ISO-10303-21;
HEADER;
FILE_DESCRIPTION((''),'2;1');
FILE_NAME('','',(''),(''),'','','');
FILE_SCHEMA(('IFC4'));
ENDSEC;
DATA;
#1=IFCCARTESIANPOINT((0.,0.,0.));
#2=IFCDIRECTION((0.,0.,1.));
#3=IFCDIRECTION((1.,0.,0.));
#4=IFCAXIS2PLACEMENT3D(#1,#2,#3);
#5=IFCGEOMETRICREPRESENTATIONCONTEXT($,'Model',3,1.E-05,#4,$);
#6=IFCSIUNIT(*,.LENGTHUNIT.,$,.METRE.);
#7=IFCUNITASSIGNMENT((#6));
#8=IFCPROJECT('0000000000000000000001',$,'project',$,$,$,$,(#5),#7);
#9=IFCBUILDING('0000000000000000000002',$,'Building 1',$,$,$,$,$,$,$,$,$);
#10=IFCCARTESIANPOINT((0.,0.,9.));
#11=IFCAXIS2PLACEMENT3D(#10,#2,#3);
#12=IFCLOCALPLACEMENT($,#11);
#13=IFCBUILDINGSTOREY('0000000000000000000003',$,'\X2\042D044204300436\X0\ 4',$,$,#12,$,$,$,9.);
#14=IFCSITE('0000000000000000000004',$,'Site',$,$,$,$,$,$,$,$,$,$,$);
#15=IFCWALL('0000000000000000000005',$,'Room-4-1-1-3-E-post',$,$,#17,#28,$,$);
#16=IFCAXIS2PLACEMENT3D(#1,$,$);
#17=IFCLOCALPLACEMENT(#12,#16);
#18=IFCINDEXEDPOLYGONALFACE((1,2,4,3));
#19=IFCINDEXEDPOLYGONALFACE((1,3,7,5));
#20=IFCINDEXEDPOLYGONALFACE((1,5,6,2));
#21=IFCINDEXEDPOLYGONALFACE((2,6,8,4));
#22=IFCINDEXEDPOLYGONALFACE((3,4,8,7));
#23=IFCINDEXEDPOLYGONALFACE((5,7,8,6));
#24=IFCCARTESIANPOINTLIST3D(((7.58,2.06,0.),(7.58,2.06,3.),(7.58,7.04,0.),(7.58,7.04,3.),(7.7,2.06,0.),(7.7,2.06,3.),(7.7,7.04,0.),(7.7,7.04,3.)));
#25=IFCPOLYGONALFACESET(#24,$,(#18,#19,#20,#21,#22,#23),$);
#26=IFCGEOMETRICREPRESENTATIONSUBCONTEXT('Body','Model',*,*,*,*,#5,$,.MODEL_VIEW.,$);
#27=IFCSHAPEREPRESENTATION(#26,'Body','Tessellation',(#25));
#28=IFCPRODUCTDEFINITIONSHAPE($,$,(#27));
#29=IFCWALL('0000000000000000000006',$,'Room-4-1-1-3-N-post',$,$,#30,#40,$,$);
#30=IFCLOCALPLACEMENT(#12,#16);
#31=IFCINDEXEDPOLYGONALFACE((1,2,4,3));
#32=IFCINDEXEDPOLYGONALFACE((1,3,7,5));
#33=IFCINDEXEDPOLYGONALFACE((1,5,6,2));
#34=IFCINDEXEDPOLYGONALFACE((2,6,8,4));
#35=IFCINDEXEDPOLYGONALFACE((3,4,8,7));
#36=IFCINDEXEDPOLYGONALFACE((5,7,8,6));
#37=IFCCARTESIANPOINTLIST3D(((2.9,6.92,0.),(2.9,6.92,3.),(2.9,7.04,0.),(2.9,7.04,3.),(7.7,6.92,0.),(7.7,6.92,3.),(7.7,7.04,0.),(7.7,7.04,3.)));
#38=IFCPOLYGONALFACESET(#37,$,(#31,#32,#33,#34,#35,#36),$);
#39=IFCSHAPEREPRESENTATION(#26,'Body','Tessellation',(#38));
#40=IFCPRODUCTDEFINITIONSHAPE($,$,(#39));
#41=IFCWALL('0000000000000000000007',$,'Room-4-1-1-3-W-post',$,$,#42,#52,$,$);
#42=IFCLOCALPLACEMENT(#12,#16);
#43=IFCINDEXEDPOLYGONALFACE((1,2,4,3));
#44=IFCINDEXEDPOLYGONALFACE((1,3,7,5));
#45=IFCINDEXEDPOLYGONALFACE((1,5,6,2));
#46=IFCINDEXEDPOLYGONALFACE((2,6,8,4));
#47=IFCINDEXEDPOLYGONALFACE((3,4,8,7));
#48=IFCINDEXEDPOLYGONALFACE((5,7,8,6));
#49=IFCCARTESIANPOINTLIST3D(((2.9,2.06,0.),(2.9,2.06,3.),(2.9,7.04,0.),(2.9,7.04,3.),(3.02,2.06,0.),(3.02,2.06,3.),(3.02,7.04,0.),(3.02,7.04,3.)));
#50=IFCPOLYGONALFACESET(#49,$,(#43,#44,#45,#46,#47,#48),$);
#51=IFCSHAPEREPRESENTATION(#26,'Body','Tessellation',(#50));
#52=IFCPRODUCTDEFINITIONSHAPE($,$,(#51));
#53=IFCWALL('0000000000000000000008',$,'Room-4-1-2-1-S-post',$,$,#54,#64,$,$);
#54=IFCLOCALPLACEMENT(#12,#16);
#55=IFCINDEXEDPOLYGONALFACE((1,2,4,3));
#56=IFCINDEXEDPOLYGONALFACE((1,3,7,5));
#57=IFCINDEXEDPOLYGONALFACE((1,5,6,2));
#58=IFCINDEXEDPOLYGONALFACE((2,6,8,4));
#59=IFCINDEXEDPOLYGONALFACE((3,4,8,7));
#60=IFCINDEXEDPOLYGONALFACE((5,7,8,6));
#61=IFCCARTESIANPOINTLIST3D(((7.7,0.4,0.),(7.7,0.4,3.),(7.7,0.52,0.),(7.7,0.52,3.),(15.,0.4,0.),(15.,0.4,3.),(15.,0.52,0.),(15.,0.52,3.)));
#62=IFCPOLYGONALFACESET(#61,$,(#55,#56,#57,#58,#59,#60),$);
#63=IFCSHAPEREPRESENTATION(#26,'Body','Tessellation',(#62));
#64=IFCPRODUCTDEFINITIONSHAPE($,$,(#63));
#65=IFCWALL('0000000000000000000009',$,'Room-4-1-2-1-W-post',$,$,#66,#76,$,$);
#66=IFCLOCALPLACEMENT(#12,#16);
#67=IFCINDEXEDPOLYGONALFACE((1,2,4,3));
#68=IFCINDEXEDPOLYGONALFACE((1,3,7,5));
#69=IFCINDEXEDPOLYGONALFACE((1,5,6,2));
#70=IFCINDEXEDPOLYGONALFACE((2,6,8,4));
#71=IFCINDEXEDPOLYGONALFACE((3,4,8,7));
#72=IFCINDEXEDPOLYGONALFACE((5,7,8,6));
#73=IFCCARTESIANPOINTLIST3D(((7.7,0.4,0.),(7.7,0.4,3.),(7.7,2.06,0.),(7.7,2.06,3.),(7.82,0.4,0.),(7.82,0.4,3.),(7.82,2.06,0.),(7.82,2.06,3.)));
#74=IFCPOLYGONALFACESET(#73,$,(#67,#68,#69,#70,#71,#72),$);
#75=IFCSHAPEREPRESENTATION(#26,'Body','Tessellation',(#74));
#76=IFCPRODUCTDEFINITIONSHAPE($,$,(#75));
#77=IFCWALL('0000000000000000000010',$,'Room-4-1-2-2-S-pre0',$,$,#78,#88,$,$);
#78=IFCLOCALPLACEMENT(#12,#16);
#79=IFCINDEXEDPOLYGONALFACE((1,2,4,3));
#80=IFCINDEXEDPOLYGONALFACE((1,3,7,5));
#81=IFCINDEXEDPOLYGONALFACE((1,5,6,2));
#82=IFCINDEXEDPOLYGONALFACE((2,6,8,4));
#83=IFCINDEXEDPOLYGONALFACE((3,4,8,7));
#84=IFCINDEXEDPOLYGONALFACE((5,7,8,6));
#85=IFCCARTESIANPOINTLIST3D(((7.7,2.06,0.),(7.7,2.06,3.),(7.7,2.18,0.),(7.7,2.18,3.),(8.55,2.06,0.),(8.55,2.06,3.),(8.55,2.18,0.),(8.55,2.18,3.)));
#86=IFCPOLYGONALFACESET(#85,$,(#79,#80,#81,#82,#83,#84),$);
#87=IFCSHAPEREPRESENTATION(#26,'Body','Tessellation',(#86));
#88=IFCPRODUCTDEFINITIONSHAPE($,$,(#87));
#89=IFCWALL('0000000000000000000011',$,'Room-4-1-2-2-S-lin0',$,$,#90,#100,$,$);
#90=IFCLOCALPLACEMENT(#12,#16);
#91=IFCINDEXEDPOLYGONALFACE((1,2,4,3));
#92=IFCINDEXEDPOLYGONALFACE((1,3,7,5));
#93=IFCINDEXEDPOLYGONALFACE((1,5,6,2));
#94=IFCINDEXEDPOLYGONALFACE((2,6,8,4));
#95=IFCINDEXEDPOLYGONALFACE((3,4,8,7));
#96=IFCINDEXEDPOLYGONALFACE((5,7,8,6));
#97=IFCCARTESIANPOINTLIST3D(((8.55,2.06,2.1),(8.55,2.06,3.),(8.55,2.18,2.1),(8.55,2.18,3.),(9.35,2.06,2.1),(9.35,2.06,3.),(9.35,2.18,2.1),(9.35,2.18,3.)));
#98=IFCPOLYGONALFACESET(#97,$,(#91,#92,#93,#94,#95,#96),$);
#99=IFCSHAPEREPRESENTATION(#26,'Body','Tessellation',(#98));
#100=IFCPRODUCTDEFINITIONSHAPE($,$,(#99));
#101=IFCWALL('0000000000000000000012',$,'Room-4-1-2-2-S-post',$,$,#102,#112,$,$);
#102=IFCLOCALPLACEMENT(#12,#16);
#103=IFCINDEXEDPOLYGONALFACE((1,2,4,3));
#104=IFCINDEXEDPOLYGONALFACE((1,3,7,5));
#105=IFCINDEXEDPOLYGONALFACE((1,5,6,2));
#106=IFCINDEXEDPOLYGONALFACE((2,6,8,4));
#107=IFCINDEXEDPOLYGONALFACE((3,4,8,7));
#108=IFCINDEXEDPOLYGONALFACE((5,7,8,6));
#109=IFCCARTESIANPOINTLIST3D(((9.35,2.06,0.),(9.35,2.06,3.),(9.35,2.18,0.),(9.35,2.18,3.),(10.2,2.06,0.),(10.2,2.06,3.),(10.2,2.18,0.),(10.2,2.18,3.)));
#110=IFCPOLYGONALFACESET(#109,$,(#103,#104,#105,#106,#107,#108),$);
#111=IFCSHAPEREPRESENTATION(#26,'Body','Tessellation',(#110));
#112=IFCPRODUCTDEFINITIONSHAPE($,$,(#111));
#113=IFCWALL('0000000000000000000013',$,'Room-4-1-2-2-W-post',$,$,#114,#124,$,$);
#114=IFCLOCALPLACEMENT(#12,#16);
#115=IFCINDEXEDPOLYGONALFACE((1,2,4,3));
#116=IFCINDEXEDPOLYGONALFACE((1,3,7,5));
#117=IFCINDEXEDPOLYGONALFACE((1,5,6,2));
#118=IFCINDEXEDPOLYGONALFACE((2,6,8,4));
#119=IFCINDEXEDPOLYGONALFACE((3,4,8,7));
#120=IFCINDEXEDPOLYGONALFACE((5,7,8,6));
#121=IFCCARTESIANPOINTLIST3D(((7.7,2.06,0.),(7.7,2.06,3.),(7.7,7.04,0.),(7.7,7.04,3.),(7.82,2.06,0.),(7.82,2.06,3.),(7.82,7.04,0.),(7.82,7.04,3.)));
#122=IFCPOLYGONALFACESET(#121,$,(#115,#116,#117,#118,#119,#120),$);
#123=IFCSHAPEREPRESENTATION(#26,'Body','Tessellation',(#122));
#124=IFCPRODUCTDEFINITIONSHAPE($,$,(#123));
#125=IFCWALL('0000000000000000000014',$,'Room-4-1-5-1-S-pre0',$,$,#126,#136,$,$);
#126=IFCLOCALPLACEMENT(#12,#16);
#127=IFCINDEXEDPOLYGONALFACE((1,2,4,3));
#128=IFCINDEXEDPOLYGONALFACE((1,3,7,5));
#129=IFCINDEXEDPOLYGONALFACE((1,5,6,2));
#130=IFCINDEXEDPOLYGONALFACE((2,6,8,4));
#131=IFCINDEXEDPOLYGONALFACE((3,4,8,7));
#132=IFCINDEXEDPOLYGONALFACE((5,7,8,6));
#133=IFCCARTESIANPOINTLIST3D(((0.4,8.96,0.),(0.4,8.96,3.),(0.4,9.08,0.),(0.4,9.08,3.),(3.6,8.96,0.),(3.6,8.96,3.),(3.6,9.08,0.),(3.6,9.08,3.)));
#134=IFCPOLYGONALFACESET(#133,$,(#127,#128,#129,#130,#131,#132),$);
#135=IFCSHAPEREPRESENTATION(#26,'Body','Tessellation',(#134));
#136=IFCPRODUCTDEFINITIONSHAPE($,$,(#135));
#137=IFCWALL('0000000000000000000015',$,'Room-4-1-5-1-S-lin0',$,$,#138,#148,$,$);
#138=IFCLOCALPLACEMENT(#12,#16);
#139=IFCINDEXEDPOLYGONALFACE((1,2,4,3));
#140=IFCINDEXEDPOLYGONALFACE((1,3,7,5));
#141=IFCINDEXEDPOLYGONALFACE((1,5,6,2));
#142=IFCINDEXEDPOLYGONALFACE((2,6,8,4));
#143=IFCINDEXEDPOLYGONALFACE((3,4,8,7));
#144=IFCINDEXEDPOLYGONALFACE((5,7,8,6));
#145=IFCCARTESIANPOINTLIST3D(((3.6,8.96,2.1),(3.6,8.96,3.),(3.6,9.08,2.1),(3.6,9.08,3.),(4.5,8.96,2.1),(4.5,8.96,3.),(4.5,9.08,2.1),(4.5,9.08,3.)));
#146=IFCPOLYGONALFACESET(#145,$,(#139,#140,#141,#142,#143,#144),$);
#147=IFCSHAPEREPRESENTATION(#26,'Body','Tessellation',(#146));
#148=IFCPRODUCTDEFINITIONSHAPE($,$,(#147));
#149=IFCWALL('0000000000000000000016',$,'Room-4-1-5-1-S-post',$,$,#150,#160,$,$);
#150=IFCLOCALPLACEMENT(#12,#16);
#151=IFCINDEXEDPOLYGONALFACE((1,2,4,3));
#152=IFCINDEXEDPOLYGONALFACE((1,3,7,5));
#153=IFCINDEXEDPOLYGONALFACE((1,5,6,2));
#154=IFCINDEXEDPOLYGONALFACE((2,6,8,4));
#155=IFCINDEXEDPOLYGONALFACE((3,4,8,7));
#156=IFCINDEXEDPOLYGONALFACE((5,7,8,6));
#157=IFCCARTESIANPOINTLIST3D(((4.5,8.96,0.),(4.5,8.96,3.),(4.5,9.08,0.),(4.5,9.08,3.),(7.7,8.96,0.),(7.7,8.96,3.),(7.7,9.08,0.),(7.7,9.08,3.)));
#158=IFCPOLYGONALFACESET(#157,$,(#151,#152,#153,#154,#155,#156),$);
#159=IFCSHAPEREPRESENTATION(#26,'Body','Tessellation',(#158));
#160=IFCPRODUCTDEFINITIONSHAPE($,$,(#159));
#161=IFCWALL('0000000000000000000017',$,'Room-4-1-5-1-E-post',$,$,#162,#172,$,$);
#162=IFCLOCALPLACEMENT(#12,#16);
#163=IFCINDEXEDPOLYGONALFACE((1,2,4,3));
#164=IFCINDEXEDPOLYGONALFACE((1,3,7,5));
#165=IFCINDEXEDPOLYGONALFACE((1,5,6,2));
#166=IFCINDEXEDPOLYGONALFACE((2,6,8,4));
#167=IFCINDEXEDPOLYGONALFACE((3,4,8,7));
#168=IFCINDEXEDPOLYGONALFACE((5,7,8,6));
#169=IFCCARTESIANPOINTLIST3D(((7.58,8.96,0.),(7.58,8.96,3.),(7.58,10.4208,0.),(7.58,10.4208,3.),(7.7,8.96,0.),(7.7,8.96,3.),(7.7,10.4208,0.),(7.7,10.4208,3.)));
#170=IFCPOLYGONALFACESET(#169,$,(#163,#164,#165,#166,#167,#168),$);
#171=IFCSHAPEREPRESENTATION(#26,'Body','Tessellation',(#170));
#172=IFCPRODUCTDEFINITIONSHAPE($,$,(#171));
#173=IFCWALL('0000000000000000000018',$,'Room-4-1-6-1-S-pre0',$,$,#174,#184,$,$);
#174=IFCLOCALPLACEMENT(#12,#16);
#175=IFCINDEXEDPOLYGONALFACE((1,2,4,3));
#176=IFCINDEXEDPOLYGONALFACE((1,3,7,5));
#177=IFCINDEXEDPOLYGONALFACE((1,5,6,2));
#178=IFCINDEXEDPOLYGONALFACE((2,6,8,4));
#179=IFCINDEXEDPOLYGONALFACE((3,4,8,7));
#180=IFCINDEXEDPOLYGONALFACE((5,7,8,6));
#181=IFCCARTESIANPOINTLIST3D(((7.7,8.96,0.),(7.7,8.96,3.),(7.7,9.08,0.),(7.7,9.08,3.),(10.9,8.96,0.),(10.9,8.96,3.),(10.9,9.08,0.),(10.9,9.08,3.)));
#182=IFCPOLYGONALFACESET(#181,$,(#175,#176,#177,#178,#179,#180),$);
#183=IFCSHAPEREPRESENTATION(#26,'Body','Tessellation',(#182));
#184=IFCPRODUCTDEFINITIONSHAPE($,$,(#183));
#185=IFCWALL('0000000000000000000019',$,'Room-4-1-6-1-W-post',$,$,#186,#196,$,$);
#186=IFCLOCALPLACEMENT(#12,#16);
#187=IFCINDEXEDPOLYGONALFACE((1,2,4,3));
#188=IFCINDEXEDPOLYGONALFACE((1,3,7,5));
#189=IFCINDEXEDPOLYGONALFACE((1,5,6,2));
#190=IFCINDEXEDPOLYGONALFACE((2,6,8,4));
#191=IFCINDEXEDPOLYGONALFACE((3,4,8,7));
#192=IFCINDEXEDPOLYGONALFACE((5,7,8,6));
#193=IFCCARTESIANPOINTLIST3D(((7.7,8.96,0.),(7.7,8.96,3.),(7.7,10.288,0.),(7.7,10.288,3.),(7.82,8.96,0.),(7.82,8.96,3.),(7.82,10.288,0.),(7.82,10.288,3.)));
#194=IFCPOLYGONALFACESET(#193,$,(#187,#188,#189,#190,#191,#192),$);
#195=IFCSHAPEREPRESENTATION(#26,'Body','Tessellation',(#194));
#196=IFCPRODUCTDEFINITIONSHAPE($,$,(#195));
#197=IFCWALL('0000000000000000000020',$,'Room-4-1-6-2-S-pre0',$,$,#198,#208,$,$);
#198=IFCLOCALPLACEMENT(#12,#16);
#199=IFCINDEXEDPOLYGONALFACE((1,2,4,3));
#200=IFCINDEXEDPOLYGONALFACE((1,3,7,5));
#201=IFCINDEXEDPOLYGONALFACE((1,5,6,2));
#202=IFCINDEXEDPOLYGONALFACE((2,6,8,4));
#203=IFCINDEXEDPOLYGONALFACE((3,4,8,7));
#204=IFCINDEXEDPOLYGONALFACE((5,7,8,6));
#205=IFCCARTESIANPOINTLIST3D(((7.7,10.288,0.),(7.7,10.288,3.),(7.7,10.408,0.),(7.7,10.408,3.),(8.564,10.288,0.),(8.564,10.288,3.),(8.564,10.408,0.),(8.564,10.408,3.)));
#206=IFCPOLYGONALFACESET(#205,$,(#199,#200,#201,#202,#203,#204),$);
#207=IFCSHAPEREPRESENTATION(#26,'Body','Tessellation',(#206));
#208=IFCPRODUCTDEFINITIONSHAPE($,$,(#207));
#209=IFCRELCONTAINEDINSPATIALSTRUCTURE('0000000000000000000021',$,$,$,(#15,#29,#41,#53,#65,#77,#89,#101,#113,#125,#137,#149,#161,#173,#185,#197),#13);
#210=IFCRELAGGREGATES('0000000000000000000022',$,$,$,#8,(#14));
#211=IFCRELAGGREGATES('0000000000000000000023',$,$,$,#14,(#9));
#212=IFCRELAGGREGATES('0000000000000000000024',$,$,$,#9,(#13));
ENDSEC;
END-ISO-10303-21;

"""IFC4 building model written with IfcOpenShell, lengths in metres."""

from ifc_helpers import new_model, si_unit, frame, origin_with_axes, place, context, subcontext, project, spatial, indexed_curve, outline, extrude, element, save


model = new_model("IFC4")

# Units and contexts
model_context = context("Model", 3, precision=1e-05, world=origin_with_axes())
body_context = subcontext(model_context, "Body", "Model", "MODEL_VIEW")
ifc_project = project(units=[si_unit("LENGTHUNIT", "METRE")], contexts=[model_context])

# Site, building, storey
site = spatial("IfcSite", under=ifc_project, Name="Site")
building = spatial("IfcBuilding", under=site, Name="Building 1")
storey_placement = place(None, frame((0.0, 0.0, 9.0), z_axis=(0.0, 0.0, 1.0), x_axis=(1.0, 0.0, 0.0)))
storey = spatial("IfcBuildingStorey", under=building, at=storey_placement, Name="Этаж 4", Elevation=9.0)

# Walls
wall_1_placement = place(storey_placement, frame((7.7, 2.06, 0.0), z_axis=(0.0, 0.0, 1.0), x_axis=(0.0, 1.0, 0.0)))
element("IfcWall", 1, at=wall_1_placement, inside=storey, Name="Room-4-1-1-3-E-post", context=body_context, shape_type="SweptSolid", body=[
    extrude(outline(indexed_curve([(0.0, 0.0), (0.0, 0.12), (4.98, 0.12), (4.98, 0.0), (0.0, 0.0)], self_intersect=False)), origin_with_axes(), (0.0, 0.0, 1.0), 3.0),
])
wall_2_placement = place(storey_placement, frame((7.7, 7.04, 0.0), z_axis=(0.0, 0.0, 1.0), x_axis=(-1.0, 0.0, 0.0)))
element("IfcWall", 2, at=wall_2_placement, inside=storey, Name="Room-4-1-1-3-N-post", context=body_context, shape_type="SweptSolid", body=[
    extrude(outline(indexed_curve([(0.0, 0.0), (0.0, 0.12), (4.8, 0.12), (4.8, 0.0), (0.0, 0.0)], self_intersect=False)), origin_with_axes(), (0.0, 0.0, 1.0), 3.0),
])
wall_3_placement = place(storey_placement, frame((2.9, 7.04, 0.0), z_axis=(0.0, 0.0, 1.0), x_axis=(0.0, -1.0, 0.0)))
element("IfcWall", 3, at=wall_3_placement, inside=storey, Name="Room-4-1-1-3-W-post", context=body_context, shape_type="SweptSolid", body=[
    extrude(outline(indexed_curve([(0.0, 0.0), (0.0, 0.12), (4.98, 0.12), (4.98, 0.0), (0.0, 0.0)], self_intersect=False)), origin_with_axes(), (0.0, 0.0, 1.0), 3.0),
])
wall_4_placement = place(storey_placement, frame((7.7, 0.4, 0.0), z_axis=(0.0, 0.0, 1.0), x_axis=(1.0, 0.0, 0.0)))
element("IfcWall", 4, at=wall_4_placement, inside=storey, Name="Room-4-1-2-1-S-post", context=body_context, shape_type="SweptSolid", body=[
    extrude(outline(indexed_curve([(0.0, 0.0), (0.0, 0.12), (7.3, 0.12), (7.3, 0.0), (0.0, 0.0)], self_intersect=False)), origin_with_axes(), (0.0, 0.0, 1.0), 3.0),
])
wall_5_placement = place(storey_placement, frame((7.7, 2.06, 0.0), z_axis=(0.0, 0.0, 1.0), x_axis=(0.0, -1.0, 0.0)))
element("IfcWall", 5, at=wall_5_placement, inside=storey, Name="Room-4-1-2-1-W-post", context=body_context, shape_type="SweptSolid", body=[
    extrude(outline(indexed_curve([(0.0, 0.0), (0.0, 0.12), (1.66, 0.12), (1.66, 0.0), (0.0, 0.0)], self_intersect=False)), origin_with_axes(), (0.0, 0.0, 1.0), 3.0),
])
wall_6_placement = place(storey_placement, frame((7.7, 2.06, 0.0), z_axis=(0.0, 0.0, 1.0), x_axis=(1.0, 0.0, 0.0)))
element("IfcWall", 6, at=wall_6_placement, inside=storey, Name="Room-4-1-2-2-S-pre0", context=body_context, shape_type="SweptSolid", body=[
    extrude(outline(indexed_curve([(0.0, 0.0), (0.0, 0.12), (0.85, 0.12), (0.85, 0.0), (0.0, 0.0)], self_intersect=False)), origin_with_axes(), (0.0, 0.0, 1.0), 3.0),
])
wall_7_placement = place(storey_placement, frame((8.55, 2.06, 2.1), z_axis=(0.0, 0.0, 1.0), x_axis=(1.0, 0.0, 0.0)))
element("IfcWall", 7, at=wall_7_placement, inside=storey, Name="Room-4-1-2-2-S-lin0", context=body_context, shape_type="SweptSolid", body=[
    extrude(outline(indexed_curve([(0.0, 0.0), (0.0, 0.12), (0.8, 0.12), (0.8, 0.0), (0.0, 0.0)], self_intersect=False)), origin_with_axes(), (0.0, 0.0, 1.0), 0.9),
])
wall_8_placement = place(storey_placement, frame((9.35, 2.06, 0.0), z_axis=(0.0, 0.0, 1.0), x_axis=(1.0, 0.0, 0.0)))
element("IfcWall", 8, at=wall_8_placement, inside=storey, Name="Room-4-1-2-2-S-post", context=body_context, shape_type="SweptSolid", body=[
    extrude(outline(indexed_curve([(0.0, 0.0), (0.0, 0.12), (0.85, 0.12), (0.85, 0.0), (0.0, 0.0)], self_intersect=False)), origin_with_axes(), (0.0, 0.0, 1.0), 3.0),
])
wall_9_placement = place(storey_placement, frame((7.7, 7.04, 0.0), z_axis=(0.0, 0.0, 1.0), x_axis=(0.0, -1.0, 0.0)))
element("IfcWall", 9, at=wall_9_placement, inside=storey, Name="Room-4-1-2-2-W-post", context=body_context, shape_type="SweptSolid", body=[
    extrude(outline(indexed_curve([(0.0, 0.0), (0.0, 0.12), (4.98, 0.12), (4.98, 0.0), (0.0, 0.0)], self_intersect=False)), origin_with_axes(), (0.0, 0.0, 1.0), 3.0),
])
wall_10_placement = place(storey_placement, frame((0.4, 8.96, 0.0), z_axis=(0.0, 0.0, 1.0), x_axis=(1.0, 0.0, 0.0)))
element("IfcWall", 10, at=wall_10_placement, inside=storey, Name="Room-4-1-5-1-S-pre0", context=body_context, shape_type="SweptSolid", body=[
    extrude(outline(indexed_curve([(0.0, 0.0), (0.0, 0.12), (3.2, 0.12), (3.2, 0.0), (0.0, 0.0)], self_intersect=False)), origin_with_axes(), (0.0, 0.0, 1.0), 3.0),
])
wall_11_placement = place(storey_placement, frame((3.6, 8.96, 2.1), z_axis=(0.0, 0.0, 1.0), x_axis=(1.0, 0.0, 0.0)))
element("IfcWall", 11, at=wall_11_placement, inside=storey, Name="Room-4-1-5-1-S-lin0", context=body_context, shape_type="SweptSolid", body=[
    extrude(outline(indexed_curve([(0.0, 0.0), (0.0, 0.12), (0.9, 0.12), (0.9, 0.0), (0.0, 0.0)], self_intersect=False)), origin_with_axes(), (0.0, 0.0, 1.0), 0.9),
])
wall_12_placement = place(storey_placement, frame((4.5, 8.96, 0.0), z_axis=(0.0, 0.0, 1.0), x_axis=(1.0, 0.0, 0.0)))
element("IfcWall", 12, at=wall_12_placement, inside=storey, Name="Room-4-1-5-1-S-post", context=body_context, shape_type="SweptSolid", body=[
    extrude(outline(indexed_curve([(0.0, 0.0), (0.0, 0.12), (3.2, 0.12), (3.2, 0.0), (0.0, 0.0)], self_intersect=False)), origin_with_axes(), (0.0, 0.0, 1.0), 3.0),
])
wall_13_placement = place(storey_placement, frame((7.7, 8.96, 0.0), z_axis=(0.0, 0.0, 1.0), x_axis=(0.0, 1.0, 0.0)))
element("IfcWall", 13, at=wall_13_placement, inside=storey, Name="Room-4-1-5-1-E-post", context=body_context, shape_type="SweptSolid", body=[
    extrude(outline(indexed_curve([(0.0, 0.0), (0.0, 0.12), (1.4608, 0.12), (1.4608, 0.0), (0.0, 0.0)], self_intersect=False)), origin_with_axes(), (0.0, 0.0, 1.0), 3.0),
])
wall_14_placement = place(storey_placement, frame((7.7, 8.96, 0.0), z_axis=(0.0, 0.0, 1.0), x_axis=(1.0, 0.0, 0.0)))
element("IfcWall", 14, at=wall_14_placement, inside=storey, Name="Room-4-1-6-1-S-pre0", context=body_context, shape_type="SweptSolid", body=[
    extrude(outline(indexed_curve([(0.0, 0.0), (0.0, 0.12), (3.2, 0.12), (3.2, 0.0), (0.0, 0.0)], self_intersect=False)), origin_with_axes(), (0.0, 0.0, 1.0), 3.0),
])
wall_15_placement = place(storey_placement, frame((7.7, 10.288, 0.0), z_axis=(0.0, 0.0, 1.0), x_axis=(0.0, -1.0, 0.0)))
element("IfcWall", 15, at=wall_15_placement, inside=storey, Name="Room-4-1-6-1-W-post", context=body_context, shape_type="SweptSolid", body=[
    extrude(outline(indexed_curve([(0.0, 0.0), (0.0, 0.12), (1.328, 0.12), (1.328, 0.0), (0.0, 0.0)], self_intersect=False)), origin_with_axes(), (0.0, 0.0, 1.0), 3.0),
])
wall_16_placement = place(storey_placement, frame((7.7, 10.288, 0.0), z_axis=(0.0, 0.0, 1.0), x_axis=(1.0, 0.0, 0.0)))
element("IfcWall", 16, at=wall_16_placement, inside=storey, Name="Room-4-1-6-2-S-pre0", context=body_context, shape_type="SweptSolid", body=[
    extrude(outline(indexed_curve([(0.0, 0.0), (0.0, 0.12), (0.864, 0.12), (0.864, 0.0), (0.0, 0.0)], self_intersect=False)), origin_with_axes(), (0.0, 0.0, 1.0), 3.0),
])

save(model, "model.ifc")
